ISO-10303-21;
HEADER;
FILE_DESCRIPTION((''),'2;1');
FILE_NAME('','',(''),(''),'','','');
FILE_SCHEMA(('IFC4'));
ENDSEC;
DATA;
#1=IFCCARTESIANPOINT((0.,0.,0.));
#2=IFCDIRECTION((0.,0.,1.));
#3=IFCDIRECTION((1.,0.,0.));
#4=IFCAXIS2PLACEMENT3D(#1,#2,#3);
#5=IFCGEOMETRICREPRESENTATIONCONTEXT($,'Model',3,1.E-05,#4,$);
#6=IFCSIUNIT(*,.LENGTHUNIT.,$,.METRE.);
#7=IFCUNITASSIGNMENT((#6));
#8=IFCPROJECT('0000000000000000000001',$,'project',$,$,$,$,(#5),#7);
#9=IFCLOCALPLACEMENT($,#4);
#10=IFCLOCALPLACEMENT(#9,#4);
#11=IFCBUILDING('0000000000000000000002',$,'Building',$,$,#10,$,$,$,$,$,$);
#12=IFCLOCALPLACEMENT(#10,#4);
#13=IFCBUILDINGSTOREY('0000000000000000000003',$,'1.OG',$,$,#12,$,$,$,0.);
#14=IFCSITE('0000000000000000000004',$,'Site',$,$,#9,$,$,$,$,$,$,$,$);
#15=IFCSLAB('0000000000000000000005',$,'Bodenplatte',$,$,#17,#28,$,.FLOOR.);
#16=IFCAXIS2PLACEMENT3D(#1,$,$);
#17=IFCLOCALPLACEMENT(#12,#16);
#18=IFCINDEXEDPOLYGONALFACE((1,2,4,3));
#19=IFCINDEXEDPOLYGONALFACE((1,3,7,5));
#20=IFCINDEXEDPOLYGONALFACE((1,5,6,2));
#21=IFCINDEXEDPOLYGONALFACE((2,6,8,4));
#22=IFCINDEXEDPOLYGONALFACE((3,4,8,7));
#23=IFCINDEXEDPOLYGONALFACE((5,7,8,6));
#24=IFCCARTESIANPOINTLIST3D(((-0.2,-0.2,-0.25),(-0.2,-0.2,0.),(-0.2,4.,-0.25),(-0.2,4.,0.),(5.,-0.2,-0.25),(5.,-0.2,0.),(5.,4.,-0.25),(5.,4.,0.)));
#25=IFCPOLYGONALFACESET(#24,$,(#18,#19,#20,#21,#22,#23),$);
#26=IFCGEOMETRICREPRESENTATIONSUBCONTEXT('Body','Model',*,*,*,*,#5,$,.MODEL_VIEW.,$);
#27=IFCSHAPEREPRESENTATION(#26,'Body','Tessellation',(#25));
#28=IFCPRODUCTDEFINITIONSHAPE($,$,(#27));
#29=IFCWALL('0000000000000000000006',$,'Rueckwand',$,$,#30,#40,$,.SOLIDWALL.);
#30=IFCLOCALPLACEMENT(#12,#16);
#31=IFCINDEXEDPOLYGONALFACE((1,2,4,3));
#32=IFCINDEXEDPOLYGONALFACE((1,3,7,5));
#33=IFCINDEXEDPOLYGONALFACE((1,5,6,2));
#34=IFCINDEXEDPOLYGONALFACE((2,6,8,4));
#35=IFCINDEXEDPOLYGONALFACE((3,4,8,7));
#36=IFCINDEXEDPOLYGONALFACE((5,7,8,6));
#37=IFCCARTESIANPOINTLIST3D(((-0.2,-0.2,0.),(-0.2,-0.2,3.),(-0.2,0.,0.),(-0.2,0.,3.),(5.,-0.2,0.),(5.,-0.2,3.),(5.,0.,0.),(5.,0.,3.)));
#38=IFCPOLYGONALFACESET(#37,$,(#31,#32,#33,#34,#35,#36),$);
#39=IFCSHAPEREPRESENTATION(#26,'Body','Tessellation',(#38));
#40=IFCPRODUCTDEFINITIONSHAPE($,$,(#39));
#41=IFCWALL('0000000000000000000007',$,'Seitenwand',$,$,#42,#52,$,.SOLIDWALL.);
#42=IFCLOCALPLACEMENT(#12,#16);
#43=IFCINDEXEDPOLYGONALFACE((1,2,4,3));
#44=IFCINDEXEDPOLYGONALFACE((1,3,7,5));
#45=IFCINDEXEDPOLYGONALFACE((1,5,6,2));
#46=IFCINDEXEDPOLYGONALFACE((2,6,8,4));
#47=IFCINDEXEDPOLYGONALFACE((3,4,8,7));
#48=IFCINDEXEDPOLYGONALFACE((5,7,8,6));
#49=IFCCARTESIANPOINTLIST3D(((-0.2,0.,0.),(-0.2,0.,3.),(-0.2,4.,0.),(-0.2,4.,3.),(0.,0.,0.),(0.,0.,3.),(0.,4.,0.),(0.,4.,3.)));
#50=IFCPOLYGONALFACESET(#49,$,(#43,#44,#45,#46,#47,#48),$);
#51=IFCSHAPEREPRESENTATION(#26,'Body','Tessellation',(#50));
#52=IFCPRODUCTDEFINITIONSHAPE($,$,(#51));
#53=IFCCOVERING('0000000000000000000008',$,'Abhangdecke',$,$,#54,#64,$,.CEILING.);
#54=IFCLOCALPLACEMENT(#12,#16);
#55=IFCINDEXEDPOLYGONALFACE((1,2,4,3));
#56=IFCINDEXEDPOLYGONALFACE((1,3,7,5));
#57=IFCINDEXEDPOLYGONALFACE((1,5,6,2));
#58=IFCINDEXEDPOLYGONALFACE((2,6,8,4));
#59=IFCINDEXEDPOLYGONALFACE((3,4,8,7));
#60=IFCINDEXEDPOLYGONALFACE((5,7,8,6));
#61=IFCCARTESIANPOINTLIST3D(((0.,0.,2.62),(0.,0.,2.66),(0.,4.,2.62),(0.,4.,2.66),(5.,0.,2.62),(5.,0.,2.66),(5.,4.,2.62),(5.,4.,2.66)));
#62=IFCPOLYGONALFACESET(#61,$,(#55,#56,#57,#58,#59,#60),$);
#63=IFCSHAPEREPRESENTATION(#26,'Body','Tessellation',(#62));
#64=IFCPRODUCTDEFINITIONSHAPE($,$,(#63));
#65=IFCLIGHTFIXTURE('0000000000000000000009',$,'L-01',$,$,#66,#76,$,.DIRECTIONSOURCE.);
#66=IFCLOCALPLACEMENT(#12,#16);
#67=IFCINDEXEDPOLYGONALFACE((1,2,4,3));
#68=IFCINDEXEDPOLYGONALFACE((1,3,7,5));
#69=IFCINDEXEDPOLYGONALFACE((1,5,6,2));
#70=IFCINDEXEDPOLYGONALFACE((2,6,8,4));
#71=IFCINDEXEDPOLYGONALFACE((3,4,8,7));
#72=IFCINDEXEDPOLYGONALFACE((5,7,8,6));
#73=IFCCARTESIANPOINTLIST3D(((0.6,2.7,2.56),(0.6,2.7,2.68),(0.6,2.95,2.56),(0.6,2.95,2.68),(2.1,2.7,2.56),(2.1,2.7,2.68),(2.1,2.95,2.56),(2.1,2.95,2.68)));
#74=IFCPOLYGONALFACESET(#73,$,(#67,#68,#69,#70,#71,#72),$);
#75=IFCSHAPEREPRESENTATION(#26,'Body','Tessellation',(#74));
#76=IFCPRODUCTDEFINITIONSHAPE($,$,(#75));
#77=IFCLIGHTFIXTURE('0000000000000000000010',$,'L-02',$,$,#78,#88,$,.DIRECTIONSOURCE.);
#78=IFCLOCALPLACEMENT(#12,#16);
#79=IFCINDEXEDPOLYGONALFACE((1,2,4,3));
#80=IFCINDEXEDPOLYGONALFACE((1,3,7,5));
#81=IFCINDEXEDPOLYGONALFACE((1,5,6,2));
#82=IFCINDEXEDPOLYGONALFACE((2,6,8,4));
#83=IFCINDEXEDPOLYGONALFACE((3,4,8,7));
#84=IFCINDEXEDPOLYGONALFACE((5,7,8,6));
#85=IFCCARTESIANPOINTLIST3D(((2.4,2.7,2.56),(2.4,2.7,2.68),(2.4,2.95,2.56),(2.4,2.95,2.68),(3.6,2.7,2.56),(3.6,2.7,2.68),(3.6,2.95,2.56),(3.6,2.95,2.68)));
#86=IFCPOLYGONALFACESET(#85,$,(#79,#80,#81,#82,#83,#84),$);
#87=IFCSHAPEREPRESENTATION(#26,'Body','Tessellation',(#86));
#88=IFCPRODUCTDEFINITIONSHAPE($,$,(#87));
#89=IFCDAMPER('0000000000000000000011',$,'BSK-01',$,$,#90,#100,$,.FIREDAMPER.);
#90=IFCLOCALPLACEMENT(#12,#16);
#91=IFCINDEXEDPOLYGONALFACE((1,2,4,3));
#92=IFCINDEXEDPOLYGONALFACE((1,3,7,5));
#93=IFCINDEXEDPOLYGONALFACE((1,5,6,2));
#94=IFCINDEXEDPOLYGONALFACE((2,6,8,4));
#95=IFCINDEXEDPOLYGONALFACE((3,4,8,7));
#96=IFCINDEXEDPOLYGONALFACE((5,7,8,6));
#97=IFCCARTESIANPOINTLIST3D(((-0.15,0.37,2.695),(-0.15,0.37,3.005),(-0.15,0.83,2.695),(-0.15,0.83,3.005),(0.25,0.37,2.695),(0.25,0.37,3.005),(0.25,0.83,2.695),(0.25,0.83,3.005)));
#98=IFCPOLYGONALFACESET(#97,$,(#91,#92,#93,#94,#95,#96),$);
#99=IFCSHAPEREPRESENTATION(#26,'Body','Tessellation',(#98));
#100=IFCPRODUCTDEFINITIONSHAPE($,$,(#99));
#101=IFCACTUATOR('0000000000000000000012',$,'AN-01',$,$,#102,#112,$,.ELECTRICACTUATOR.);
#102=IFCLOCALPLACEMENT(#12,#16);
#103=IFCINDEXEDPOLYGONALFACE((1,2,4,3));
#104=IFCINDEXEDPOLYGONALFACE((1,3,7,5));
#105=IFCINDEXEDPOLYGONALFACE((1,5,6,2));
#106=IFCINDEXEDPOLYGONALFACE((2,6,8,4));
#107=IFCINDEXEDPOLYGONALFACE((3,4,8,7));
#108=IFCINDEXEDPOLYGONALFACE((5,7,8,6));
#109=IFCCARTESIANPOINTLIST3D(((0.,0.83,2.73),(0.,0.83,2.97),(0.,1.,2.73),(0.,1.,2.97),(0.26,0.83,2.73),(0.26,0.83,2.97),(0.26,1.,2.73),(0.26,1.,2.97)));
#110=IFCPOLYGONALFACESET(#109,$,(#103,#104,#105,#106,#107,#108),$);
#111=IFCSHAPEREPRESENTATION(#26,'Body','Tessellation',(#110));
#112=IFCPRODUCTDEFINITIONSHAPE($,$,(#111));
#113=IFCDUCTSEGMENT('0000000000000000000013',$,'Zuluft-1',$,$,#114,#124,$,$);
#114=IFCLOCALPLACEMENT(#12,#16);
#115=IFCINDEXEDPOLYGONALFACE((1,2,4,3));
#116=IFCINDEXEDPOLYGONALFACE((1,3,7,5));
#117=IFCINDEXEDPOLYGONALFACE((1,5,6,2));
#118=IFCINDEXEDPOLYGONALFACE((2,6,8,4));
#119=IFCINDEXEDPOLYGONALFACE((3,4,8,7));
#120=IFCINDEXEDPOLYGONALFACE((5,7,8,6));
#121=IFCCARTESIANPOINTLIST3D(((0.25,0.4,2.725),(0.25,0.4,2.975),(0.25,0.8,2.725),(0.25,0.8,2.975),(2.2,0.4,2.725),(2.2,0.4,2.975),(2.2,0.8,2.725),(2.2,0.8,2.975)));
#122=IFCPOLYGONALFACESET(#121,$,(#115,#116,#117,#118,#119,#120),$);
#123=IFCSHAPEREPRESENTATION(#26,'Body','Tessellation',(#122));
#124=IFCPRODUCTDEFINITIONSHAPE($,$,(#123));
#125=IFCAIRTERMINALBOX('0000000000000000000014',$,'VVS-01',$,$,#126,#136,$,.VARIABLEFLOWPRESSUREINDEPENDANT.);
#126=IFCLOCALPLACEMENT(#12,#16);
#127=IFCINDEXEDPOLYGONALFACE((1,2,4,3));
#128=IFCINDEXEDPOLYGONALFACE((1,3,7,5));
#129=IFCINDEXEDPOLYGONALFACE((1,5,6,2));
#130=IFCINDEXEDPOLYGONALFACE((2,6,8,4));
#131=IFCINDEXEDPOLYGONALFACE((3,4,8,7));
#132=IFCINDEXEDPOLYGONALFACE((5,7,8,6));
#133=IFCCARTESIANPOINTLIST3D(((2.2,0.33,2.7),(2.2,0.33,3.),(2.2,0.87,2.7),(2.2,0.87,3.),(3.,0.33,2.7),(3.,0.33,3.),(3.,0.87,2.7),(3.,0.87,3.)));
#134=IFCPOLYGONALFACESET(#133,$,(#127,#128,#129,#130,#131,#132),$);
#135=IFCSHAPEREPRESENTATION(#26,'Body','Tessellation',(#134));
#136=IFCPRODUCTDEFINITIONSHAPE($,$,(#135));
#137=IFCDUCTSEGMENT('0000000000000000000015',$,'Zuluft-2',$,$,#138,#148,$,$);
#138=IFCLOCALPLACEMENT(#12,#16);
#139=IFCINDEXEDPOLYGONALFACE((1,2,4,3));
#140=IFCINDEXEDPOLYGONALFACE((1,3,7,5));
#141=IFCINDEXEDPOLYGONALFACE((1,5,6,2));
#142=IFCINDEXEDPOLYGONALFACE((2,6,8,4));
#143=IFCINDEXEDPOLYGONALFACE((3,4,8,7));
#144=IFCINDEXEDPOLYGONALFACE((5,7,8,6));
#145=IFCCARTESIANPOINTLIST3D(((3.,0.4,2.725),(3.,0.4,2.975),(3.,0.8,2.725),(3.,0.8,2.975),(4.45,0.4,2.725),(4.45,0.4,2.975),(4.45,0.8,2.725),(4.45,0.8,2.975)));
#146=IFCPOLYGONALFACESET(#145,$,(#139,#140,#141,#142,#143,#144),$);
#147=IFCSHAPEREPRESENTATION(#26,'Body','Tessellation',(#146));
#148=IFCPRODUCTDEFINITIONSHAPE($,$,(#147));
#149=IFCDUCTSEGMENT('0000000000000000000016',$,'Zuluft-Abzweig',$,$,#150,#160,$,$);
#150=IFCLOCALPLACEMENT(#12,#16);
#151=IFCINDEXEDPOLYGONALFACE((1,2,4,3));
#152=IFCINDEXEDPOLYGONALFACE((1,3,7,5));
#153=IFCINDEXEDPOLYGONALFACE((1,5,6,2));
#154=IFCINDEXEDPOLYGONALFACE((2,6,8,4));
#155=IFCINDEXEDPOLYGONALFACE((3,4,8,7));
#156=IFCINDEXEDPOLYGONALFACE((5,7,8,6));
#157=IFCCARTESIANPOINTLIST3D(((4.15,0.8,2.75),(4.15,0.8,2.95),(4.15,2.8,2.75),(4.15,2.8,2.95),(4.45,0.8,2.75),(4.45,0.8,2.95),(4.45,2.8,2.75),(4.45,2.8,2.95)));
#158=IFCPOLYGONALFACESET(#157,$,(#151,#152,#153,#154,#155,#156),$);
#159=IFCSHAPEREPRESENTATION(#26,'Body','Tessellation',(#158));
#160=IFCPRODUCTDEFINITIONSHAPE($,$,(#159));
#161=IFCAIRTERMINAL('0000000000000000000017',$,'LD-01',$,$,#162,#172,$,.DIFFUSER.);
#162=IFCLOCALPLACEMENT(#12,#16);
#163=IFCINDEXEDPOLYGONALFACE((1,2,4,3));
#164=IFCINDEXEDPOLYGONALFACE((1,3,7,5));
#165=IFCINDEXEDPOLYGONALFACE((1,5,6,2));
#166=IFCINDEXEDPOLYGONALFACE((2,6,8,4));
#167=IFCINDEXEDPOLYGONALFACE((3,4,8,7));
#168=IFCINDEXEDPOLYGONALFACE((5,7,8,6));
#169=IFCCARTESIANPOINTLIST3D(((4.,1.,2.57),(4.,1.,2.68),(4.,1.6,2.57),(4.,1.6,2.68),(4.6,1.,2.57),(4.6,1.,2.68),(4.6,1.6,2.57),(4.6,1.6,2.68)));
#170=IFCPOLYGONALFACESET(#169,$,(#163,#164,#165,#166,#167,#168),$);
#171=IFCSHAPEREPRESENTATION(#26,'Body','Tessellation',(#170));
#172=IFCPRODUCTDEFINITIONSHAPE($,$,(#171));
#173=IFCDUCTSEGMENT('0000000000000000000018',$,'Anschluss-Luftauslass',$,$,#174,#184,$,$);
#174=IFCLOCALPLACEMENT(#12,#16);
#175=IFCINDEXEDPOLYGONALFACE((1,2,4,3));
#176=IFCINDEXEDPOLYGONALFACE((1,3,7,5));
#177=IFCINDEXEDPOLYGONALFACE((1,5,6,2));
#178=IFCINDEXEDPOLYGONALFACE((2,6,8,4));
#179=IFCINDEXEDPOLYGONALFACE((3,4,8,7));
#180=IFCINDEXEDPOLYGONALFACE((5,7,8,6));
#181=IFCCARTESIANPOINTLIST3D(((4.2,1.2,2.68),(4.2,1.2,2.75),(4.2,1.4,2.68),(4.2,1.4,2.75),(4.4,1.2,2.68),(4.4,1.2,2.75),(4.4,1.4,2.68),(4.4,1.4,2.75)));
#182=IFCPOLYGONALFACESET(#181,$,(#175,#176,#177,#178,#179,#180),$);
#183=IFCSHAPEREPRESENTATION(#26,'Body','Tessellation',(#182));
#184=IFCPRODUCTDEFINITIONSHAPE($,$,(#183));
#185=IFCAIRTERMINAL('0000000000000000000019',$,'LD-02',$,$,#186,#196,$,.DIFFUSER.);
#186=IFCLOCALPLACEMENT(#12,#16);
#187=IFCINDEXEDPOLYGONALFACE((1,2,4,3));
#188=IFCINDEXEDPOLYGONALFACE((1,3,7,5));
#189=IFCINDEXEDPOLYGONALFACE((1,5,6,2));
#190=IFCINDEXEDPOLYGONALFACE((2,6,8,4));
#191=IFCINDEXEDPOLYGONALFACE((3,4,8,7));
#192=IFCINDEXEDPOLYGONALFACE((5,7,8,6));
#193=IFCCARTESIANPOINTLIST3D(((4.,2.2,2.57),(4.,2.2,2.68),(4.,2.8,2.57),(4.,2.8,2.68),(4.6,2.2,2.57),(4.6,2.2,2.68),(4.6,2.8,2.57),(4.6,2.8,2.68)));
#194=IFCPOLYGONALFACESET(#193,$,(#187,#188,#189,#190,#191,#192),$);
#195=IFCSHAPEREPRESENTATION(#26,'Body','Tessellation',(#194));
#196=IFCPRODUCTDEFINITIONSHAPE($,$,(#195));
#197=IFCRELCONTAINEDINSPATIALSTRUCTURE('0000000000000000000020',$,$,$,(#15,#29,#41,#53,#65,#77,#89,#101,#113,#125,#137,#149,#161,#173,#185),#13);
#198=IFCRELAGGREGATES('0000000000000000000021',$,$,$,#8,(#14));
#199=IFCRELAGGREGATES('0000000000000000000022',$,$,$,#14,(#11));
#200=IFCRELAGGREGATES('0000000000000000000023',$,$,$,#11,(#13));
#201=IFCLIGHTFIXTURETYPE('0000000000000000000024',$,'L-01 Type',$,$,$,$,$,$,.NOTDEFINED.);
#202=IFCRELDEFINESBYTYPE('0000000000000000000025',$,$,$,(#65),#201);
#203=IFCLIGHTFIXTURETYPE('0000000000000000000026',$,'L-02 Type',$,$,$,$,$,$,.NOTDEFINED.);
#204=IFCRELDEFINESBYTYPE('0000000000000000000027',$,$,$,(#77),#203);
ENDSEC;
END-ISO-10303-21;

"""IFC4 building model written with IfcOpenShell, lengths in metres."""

from ifc_helpers import new_model, si_unit, frame, origin_with_axes, place, context, subcontext, project, spatial, polyline, outline, extrude, type_object, element, save


model = new_model("IFC4")

# Units and contexts
model_context = context("Model", 3, precision=1e-05, world=origin_with_axes())
body_context = subcontext(model_context, "Body", "Model", "MODEL_VIEW")
ifc_project = project(units=[si_unit("LENGTHUNIT", "METRE")], contexts=[model_context])

# Site, building, storey
site_placement = place(None, origin_with_axes())
site = spatial("IfcSite", under=ifc_project, at=site_placement, Name="Site")
building_placement = place(site_placement, origin_with_axes())
building = spatial("IfcBuilding", under=site, at=building_placement, Name="Building")
storey_placement = place(building_placement, origin_with_axes())
storey = spatial("IfcBuildingStorey", under=building, at=storey_placement, Name="1.OG", Elevation=0.0)

# Slab
slab_placement = place(storey_placement, frame((0.0, 0.0, -0.25), z_axis=(0.0, 0.0, 1.0), x_axis=(1.0, 0.0, 0.0)))
element("IfcSlab", 1, at=slab_placement, inside=storey, Name="Bodenplatte", PredefinedType="FLOOR", context=body_context, shape_type="SweptSolid", body=[
    extrude(outline(polyline([(-0.2, -0.2, 0.0), (5.0, -0.2, 0.0), (5.0, 4.0, 0.0), (-0.2, 4.0, 0.0), (-0.2, -0.2, 0.0)])), origin_with_axes(), (0.0, 0.0, 1.0), 0.25),
])

# Walls
wall_1_placement = place(storey_placement, frame((-0.2, -0.2, 0.0), z_axis=(0.0, 0.0, 1.0), x_axis=(1.0, 0.0, 0.0)))
element("IfcWall", 2, at=wall_1_placement, inside=storey, Name="Rueckwand", PredefinedType="SOLIDWALL", context=body_context, shape_type="SweptSolid", body=[
    extrude(outline(polyline([(0.0, 0.0, 0.0), (5.2, 0.0, 0.0), (5.2, 0.2, 0.0), (0.0, 0.2, 0.0), (0.0, 0.0, 0.0)])), origin_with_axes(), (0.0, 0.0, 1.0), 3.0),
])
wall_2_placement = place(storey_placement, frame((0.0, 0.0, 0.0), z_axis=(0.0, 0.0, 1.0), x_axis=(0.0, 1.0, 0.0)))
element("IfcWall", 3, at=wall_2_placement, inside=storey, Name="Seitenwand", PredefinedType="SOLIDWALL", context=body_context, shape_type="SweptSolid", body=[
    extrude(outline(polyline([(0.0, 0.0, 0.0), (4.0, 0.0, 0.0), (4.0, 0.2, 0.0), (0.0, 0.2, 0.0), (0.0, 0.0, 0.0)])), origin_with_axes(), (0.0, 0.0, 1.0), 3.0),
])

# Covering
covering_placement = place(storey_placement, frame((0.0, 0.0, 2.62), z_axis=(0.0, 0.0, 1.0), x_axis=(1.0, 0.0, 0.0)))
element("IfcCovering", 4, at=covering_placement, inside=storey, Name="Abhangdecke", PredefinedType="CEILING", context=body_context, shape_type="SweptSolid", body=[
    extrude(outline(polyline([(0.0, 0.0, 0.0), (5.0, 0.0, 0.0), (5.0, 4.0, 0.0), (0.0, 4.0, 0.0), (0.0, 0.0, 0.0)])), origin_with_axes(), (0.0, 0.0, 1.0), 0.04),
])

# Light fixtures
light_fixture_type_1 = type_object("IfcLightFixtureType", Name="L-01 Type", PredefinedType="NOTDEFINED")
light_fixture_1_placement = place(storey_placement, origin_with_axes())
element("IfcLightFixture", 5, at=light_fixture_1_placement, inside=storey, type_object=light_fixture_type_1, Name="L-01", PredefinedType="DIRECTIONSOURCE", context=body_context, shape_type="SweptSolid", body=[
    extrude(outline(polyline([(0.6, 2.7, 0.0), (2.1, 2.7, 0.0), (2.1, 2.95, 0.0), (0.6, 2.95, 0.0), (0.6, 2.7, 0.0)])), frame((0.0, 0.0, 2.56), z_axis=(0.0, 0.0, 1.0), x_axis=(1.0, 0.0, 0.0)), (0.0, 0.0, 1.0), 0.12),
])
light_fixture_type_2 = type_object("IfcLightFixtureType", Name="L-02 Type", PredefinedType="NOTDEFINED")
light_fixture_2_placement = place(storey_placement, origin_with_axes())
element("IfcLightFixture", 6, at=light_fixture_2_placement, inside=storey, type_object=light_fixture_type_2, Name="L-02", PredefinedType="DIRECTIONSOURCE", context=body_context, shape_type="SweptSolid", body=[
    extrude(outline(polyline([(2.4, 2.7, 0.0), (3.6, 2.7, 0.0), (3.6, 2.95, 0.0), (2.4, 2.95, 0.0), (2.4, 2.7, 0.0)])), frame((0.0, 0.0, 2.56), z_axis=(0.0, 0.0, 1.0), x_axis=(1.0, 0.0, 0.0)), (0.0, 0.0, 1.0), 0.12),
])

# Damper
damper_placement = place(storey_placement, origin_with_axes())
element("IfcDamper", 7, at=damper_placement, inside=storey, Name="BSK-01", PredefinedType="FIREDAMPER", context=body_context, shape_type="SweptSolid", body=[
    extrude(outline(polyline([(-0.15, 0.37, 0.0), (0.25, 0.37, 0.0), (0.25, 0.83, 0.0), (-0.15, 0.83, 0.0), (-0.15, 0.37, 0.0)])), frame((0.0, 0.0, 2.695), z_axis=(0.0, 0.0, 1.0), x_axis=(1.0, 0.0, 0.0)), (0.0, 0.0, 1.0), 0.31),
])

# Actuator
actuator_placement = place(storey_placement, origin_with_axes())
element("IfcActuator", 8, at=actuator_placement, inside=storey, Name="AN-01", PredefinedType="ELECTRICACTUATOR", context=body_context, shape_type="SweptSolid", body=[
    extrude(outline(polyline([(0.0, 0.83, 0.0), (0.26, 0.83, 0.0), (0.26, 1.0, 0.0), (0.0, 1.0, 0.0), (0.0, 0.83, 0.0)])), frame((0.0, 0.0, 2.73), z_axis=(0.0, 0.0, 1.0), x_axis=(1.0, 0.0, 0.0)), (0.0, 0.0, 1.0), 0.24),
])

# Duct segment
duct_segment_1_placement = place(storey_placement, origin_with_axes())
element("IfcDuctSegment", 9, at=duct_segment_1_placement, inside=storey, Name="Zuluft-1", context=body_context, shape_type="SweptSolid", body=[
    extrude(outline(polyline([(-0.2, -0.125, 0.0), (0.2, -0.125, 0.0), (0.2, 0.125, 0.0), (-0.2, 0.125, 0.0), (-0.2, -0.125, 0.0)])), frame((0.25, 0.6, 2.85), z_axis=(1.0, 0.0, 0.0), x_axis=(0.0, 1.0, 0.0)), (0.0, 0.0, 1.0), 1.95),
])

# Air terminal box
air_terminal_box_placement = place(storey_placement, origin_with_axes())
element("IfcAirTerminalBox", 10, at=air_terminal_box_placement, inside=storey, Name="VVS-01", PredefinedType="VARIABLEFLOWPRESSUREINDEPENDANT", context=body_context, shape_type="SweptSolid", body=[
    extrude(outline(polyline([(2.2, 0.33, 0.0), (3.0, 0.33, 0.0), (3.0, 0.87, 0.0), (2.2, 0.87, 0.0), (2.2, 0.33, 0.0)])), frame((0.0, 0.0, 2.7), z_axis=(0.0, 0.0, 1.0), x_axis=(1.0, 0.0, 0.0)), (0.0, 0.0, 1.0), 0.3),
])

# Duct segments
duct_segment_2_placement = place(storey_placement, origin_with_axes())
element("IfcDuctSegment", 11, at=duct_segment_2_placement, inside=storey, Name="Zuluft-2", context=body_context, shape_type="SweptSolid", body=[
    extrude(outline(polyline([(-0.2, -0.125, 0.0), (0.2, -0.125, 0.0), (0.2, 0.125, 0.0), (-0.2, 0.125, 0.0), (-0.2, -0.125, 0.0)])), frame((3.0, 0.6, 2.85), z_axis=(1.0, 0.0, 0.0), x_axis=(0.0, 1.0, 0.0)), (0.0, 0.0, 1.0), 1.45),
])
duct_segment_3_placement = place(storey_placement, origin_with_axes())
element("IfcDuctSegment", 12, at=duct_segment_3_placement, inside=storey, Name="Zuluft-Abzweig", context=body_context, shape_type="SweptSolid", body=[
    extrude(outline(polyline([(-0.15, -0.1, 0.0), (0.15, -0.1, 0.0), (0.15, 0.1, 0.0), (-0.15, 0.1, 0.0), (-0.15, -0.1, 0.0)])), frame((4.3, 0.8, 2.85), z_axis=(0.0, 1.0, 0.0), x_axis=(-1.0, 0.0, 0.0)), (0.0, 0.0, 1.0), 2.0),
])

# Air terminal
air_terminal_1_placement = place(storey_placement, origin_with_axes())
element("IfcAirTerminal", 13, at=air_terminal_1_placement, inside=storey, Name="LD-01", PredefinedType="DIFFUSER", context=body_context, shape_type="SweptSolid", body=[
    extrude(outline(polyline([(4.0, 1.0, 0.0), (4.6, 1.0, 0.0), (4.6, 1.6, 0.0), (4.0, 1.6, 0.0), (4.0, 1.0, 0.0)])), frame((0.0, 0.0, 2.57), z_axis=(0.0, 0.0, 1.0), x_axis=(1.0, 0.0, 0.0)), (0.0, 0.0, 1.0), 0.11),
])

# Duct segment
duct_segment_4_placement = place(storey_placement, origin_with_axes())
element("IfcDuctSegment", 14, at=duct_segment_4_placement, inside=storey, Name="Anschluss-Luftauslass", context=body_context, shape_type="SweptSolid", body=[
    extrude(outline(polyline([(-0.1, -0.1, 0.0), (0.1, -0.1, 0.0), (0.1, 0.1, 0.0), (-0.1, 0.1, 0.0), (-0.1, -0.1, 0.0)])), frame((4.3, 1.3, 2.68), z_axis=(0.0, 0.0, 1.0), x_axis=(1.0, 0.0, 0.0)), (0.0, 0.0, 1.0), 0.07),
])

# Air terminal
air_terminal_2_placement = place(storey_placement, origin_with_axes())
element("IfcAirTerminal", 15, at=air_terminal_2_placement, inside=storey, Name="LD-02", PredefinedType="DIFFUSER", context=body_context, shape_type="SweptSolid", body=[
    extrude(outline(polyline([(4.0, 2.2, 0.0), (4.6, 2.2, 0.0), (4.6, 2.8, 0.0), (4.0, 2.8, 0.0), (4.0, 2.2, 0.0)])), frame((0.0, 0.0, 2.57), z_axis=(0.0, 0.0, 1.0), x_axis=(1.0, 0.0, 0.0)), (0.0, 0.0, 1.0), 0.11),
])

save(model, "model.ifc")
